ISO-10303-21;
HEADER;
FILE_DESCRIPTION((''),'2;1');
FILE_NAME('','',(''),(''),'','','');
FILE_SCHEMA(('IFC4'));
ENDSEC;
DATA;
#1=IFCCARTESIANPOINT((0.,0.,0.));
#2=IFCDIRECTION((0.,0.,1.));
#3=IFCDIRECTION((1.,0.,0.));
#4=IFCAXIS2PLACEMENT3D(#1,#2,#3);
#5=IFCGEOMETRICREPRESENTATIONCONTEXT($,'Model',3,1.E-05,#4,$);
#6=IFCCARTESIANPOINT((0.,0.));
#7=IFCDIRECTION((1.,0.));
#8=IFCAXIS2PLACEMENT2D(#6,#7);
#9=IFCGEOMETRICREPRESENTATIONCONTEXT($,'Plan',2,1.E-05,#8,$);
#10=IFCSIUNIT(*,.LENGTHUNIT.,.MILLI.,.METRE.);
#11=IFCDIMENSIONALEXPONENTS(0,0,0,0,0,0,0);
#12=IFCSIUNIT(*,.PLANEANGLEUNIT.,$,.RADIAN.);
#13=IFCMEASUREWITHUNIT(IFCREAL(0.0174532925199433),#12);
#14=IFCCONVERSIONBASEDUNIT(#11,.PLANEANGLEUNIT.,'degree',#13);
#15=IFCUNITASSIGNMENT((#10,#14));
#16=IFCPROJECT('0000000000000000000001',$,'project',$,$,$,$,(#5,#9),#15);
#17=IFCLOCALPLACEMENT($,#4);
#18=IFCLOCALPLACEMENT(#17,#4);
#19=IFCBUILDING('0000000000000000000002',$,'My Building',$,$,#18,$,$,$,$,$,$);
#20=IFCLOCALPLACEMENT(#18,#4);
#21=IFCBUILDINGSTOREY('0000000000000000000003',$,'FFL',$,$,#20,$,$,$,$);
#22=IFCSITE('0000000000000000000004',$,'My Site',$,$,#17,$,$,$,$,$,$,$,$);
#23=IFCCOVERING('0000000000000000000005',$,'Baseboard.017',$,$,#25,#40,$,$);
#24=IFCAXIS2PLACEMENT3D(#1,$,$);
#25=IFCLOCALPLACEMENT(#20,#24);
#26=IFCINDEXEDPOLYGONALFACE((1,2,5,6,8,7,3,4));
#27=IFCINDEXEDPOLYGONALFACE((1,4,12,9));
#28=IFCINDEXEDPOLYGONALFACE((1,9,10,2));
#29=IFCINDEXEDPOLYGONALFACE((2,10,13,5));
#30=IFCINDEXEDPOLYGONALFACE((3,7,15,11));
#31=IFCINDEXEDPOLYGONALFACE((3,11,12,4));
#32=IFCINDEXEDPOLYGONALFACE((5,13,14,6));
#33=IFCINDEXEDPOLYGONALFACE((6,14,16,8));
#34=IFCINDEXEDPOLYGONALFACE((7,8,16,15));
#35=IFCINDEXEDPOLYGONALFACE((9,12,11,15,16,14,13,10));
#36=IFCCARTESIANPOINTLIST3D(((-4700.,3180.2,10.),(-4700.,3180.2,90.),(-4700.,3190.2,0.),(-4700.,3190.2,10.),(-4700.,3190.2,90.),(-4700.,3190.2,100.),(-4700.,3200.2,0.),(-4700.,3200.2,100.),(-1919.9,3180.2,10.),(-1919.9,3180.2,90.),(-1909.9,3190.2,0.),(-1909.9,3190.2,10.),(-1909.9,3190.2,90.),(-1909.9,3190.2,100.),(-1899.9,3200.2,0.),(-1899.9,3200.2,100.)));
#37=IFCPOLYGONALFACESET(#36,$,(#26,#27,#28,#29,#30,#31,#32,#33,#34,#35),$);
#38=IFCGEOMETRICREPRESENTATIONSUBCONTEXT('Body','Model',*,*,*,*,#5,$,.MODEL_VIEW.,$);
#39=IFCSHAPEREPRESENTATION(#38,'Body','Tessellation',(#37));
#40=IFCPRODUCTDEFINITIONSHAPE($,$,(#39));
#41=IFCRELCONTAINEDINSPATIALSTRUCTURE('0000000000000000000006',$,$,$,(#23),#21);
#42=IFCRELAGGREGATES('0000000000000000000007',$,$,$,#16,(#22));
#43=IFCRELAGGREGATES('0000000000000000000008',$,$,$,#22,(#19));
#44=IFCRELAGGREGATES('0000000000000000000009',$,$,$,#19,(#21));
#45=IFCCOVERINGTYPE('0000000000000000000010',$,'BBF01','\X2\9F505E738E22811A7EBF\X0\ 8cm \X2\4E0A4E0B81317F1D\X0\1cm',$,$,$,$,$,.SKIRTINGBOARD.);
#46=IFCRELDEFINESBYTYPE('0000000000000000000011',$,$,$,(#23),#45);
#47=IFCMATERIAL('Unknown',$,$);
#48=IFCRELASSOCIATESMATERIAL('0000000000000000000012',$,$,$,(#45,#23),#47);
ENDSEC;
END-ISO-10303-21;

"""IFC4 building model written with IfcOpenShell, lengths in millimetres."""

from ifc_helpers import new_model, entity, si_unit, converted_unit, frame, origin_with_axes, origin_2d_with_axis, place, context, subcontext, project, spatial, indexed_curve, outline, extrude, clip, halfspace, material, material_profile, profile_set, profile_usage, type_object, element, save


model = new_model("IFC4")

# Units and contexts
model_context = context("Model", 3, precision=1e-05, world=origin_with_axes())
plan_context = context("Plan", 2, precision=1e-05, world=origin_2d_with_axis())
body_context_1 = subcontext(model_context, "Body", "Model", "MODEL_VIEW")
ifc_project = project(units=[si_unit("LENGTHUNIT", "METRE", prefix="MILLI"), converted_unit("PLANEANGLEUNIT", "degree", entity("IfcReal", 0.0174532925199433), si_unit("PLANEANGLEUNIT", "RADIAN"), dimensions=[0, 0, 0, 0, 0, 0, 0])], contexts=[model_context, plan_context])

# Site, building, storey
site_placement = place(None, origin_with_axes())
site = spatial("IfcSite", under=ifc_project, at=site_placement, Name="My Site")
building_placement = place(site_placement, origin_with_axes())
building = spatial("IfcBuilding", under=site, at=building_placement, Name="My Building")
storey_placement = place(building_placement, origin_with_axes())
storey = spatial("IfcBuildingStorey", under=building, at=storey_placement, Name="FFL")

# Covering
ifc_material_1 = material(Name="Unknown")
ifc_material_profile_1 = material_profile(ifc_material_1, outline(indexed_curve([(0.0, 100.0), (10.0, 100.0), (10.0, 90.0), (20.0, 90.0), (20.0, 10.0), (10.0, 10.0), (10.0, 0.0), (0.0, 0.0), (0.0, 100.0)])))
ifc_profile_set_1 = profile_set([ifc_material_profile_1])
covering_type = type_object("IfcCoveringType", Name="BBF01", Description="齐平踢脚线 8cm 上下脱缝1cm", PredefinedType="SKIRTINGBOARD", material=ifc_profile_set_1)
ifc_profile_usage_1 = profile_usage(ifc_profile_set_1, cardinal=5)
covering_1_placement = place(storey_placement, frame((-1899.9, 3200.2, 0.0), z_axis=(-1.0, 0.0, 0.0), x_axis=(0.0, -1.0, 0.0)))
element("IfcCovering", 1, at=covering_1_placement, inside=storey, type_object=covering_type, material=ifc_profile_usage_1, Name="Baseboard.017", context=body_context_1, shape_type="Clipping", body=[
    clip(extrude(outline(indexed_curve([(0.0, 100.0), (10.0, 100.0), (10.0, 90.0), (20.0, 90.0), (20.0, 10.0), (10.0, 10.0), (10.0, 0.0), (0.0, 0.0), (0.0, 100.0)])), origin_with_axes(), (0.0, 0.0, 1.0), 2800.1), halfspace(frame((0.0, 0.0, 0.0), z_axis=(0.707106, 0.0, -0.707107), x_axis=(0.0, -1.0, 0.0)), False)),
])

save(model, "model.ifc")
